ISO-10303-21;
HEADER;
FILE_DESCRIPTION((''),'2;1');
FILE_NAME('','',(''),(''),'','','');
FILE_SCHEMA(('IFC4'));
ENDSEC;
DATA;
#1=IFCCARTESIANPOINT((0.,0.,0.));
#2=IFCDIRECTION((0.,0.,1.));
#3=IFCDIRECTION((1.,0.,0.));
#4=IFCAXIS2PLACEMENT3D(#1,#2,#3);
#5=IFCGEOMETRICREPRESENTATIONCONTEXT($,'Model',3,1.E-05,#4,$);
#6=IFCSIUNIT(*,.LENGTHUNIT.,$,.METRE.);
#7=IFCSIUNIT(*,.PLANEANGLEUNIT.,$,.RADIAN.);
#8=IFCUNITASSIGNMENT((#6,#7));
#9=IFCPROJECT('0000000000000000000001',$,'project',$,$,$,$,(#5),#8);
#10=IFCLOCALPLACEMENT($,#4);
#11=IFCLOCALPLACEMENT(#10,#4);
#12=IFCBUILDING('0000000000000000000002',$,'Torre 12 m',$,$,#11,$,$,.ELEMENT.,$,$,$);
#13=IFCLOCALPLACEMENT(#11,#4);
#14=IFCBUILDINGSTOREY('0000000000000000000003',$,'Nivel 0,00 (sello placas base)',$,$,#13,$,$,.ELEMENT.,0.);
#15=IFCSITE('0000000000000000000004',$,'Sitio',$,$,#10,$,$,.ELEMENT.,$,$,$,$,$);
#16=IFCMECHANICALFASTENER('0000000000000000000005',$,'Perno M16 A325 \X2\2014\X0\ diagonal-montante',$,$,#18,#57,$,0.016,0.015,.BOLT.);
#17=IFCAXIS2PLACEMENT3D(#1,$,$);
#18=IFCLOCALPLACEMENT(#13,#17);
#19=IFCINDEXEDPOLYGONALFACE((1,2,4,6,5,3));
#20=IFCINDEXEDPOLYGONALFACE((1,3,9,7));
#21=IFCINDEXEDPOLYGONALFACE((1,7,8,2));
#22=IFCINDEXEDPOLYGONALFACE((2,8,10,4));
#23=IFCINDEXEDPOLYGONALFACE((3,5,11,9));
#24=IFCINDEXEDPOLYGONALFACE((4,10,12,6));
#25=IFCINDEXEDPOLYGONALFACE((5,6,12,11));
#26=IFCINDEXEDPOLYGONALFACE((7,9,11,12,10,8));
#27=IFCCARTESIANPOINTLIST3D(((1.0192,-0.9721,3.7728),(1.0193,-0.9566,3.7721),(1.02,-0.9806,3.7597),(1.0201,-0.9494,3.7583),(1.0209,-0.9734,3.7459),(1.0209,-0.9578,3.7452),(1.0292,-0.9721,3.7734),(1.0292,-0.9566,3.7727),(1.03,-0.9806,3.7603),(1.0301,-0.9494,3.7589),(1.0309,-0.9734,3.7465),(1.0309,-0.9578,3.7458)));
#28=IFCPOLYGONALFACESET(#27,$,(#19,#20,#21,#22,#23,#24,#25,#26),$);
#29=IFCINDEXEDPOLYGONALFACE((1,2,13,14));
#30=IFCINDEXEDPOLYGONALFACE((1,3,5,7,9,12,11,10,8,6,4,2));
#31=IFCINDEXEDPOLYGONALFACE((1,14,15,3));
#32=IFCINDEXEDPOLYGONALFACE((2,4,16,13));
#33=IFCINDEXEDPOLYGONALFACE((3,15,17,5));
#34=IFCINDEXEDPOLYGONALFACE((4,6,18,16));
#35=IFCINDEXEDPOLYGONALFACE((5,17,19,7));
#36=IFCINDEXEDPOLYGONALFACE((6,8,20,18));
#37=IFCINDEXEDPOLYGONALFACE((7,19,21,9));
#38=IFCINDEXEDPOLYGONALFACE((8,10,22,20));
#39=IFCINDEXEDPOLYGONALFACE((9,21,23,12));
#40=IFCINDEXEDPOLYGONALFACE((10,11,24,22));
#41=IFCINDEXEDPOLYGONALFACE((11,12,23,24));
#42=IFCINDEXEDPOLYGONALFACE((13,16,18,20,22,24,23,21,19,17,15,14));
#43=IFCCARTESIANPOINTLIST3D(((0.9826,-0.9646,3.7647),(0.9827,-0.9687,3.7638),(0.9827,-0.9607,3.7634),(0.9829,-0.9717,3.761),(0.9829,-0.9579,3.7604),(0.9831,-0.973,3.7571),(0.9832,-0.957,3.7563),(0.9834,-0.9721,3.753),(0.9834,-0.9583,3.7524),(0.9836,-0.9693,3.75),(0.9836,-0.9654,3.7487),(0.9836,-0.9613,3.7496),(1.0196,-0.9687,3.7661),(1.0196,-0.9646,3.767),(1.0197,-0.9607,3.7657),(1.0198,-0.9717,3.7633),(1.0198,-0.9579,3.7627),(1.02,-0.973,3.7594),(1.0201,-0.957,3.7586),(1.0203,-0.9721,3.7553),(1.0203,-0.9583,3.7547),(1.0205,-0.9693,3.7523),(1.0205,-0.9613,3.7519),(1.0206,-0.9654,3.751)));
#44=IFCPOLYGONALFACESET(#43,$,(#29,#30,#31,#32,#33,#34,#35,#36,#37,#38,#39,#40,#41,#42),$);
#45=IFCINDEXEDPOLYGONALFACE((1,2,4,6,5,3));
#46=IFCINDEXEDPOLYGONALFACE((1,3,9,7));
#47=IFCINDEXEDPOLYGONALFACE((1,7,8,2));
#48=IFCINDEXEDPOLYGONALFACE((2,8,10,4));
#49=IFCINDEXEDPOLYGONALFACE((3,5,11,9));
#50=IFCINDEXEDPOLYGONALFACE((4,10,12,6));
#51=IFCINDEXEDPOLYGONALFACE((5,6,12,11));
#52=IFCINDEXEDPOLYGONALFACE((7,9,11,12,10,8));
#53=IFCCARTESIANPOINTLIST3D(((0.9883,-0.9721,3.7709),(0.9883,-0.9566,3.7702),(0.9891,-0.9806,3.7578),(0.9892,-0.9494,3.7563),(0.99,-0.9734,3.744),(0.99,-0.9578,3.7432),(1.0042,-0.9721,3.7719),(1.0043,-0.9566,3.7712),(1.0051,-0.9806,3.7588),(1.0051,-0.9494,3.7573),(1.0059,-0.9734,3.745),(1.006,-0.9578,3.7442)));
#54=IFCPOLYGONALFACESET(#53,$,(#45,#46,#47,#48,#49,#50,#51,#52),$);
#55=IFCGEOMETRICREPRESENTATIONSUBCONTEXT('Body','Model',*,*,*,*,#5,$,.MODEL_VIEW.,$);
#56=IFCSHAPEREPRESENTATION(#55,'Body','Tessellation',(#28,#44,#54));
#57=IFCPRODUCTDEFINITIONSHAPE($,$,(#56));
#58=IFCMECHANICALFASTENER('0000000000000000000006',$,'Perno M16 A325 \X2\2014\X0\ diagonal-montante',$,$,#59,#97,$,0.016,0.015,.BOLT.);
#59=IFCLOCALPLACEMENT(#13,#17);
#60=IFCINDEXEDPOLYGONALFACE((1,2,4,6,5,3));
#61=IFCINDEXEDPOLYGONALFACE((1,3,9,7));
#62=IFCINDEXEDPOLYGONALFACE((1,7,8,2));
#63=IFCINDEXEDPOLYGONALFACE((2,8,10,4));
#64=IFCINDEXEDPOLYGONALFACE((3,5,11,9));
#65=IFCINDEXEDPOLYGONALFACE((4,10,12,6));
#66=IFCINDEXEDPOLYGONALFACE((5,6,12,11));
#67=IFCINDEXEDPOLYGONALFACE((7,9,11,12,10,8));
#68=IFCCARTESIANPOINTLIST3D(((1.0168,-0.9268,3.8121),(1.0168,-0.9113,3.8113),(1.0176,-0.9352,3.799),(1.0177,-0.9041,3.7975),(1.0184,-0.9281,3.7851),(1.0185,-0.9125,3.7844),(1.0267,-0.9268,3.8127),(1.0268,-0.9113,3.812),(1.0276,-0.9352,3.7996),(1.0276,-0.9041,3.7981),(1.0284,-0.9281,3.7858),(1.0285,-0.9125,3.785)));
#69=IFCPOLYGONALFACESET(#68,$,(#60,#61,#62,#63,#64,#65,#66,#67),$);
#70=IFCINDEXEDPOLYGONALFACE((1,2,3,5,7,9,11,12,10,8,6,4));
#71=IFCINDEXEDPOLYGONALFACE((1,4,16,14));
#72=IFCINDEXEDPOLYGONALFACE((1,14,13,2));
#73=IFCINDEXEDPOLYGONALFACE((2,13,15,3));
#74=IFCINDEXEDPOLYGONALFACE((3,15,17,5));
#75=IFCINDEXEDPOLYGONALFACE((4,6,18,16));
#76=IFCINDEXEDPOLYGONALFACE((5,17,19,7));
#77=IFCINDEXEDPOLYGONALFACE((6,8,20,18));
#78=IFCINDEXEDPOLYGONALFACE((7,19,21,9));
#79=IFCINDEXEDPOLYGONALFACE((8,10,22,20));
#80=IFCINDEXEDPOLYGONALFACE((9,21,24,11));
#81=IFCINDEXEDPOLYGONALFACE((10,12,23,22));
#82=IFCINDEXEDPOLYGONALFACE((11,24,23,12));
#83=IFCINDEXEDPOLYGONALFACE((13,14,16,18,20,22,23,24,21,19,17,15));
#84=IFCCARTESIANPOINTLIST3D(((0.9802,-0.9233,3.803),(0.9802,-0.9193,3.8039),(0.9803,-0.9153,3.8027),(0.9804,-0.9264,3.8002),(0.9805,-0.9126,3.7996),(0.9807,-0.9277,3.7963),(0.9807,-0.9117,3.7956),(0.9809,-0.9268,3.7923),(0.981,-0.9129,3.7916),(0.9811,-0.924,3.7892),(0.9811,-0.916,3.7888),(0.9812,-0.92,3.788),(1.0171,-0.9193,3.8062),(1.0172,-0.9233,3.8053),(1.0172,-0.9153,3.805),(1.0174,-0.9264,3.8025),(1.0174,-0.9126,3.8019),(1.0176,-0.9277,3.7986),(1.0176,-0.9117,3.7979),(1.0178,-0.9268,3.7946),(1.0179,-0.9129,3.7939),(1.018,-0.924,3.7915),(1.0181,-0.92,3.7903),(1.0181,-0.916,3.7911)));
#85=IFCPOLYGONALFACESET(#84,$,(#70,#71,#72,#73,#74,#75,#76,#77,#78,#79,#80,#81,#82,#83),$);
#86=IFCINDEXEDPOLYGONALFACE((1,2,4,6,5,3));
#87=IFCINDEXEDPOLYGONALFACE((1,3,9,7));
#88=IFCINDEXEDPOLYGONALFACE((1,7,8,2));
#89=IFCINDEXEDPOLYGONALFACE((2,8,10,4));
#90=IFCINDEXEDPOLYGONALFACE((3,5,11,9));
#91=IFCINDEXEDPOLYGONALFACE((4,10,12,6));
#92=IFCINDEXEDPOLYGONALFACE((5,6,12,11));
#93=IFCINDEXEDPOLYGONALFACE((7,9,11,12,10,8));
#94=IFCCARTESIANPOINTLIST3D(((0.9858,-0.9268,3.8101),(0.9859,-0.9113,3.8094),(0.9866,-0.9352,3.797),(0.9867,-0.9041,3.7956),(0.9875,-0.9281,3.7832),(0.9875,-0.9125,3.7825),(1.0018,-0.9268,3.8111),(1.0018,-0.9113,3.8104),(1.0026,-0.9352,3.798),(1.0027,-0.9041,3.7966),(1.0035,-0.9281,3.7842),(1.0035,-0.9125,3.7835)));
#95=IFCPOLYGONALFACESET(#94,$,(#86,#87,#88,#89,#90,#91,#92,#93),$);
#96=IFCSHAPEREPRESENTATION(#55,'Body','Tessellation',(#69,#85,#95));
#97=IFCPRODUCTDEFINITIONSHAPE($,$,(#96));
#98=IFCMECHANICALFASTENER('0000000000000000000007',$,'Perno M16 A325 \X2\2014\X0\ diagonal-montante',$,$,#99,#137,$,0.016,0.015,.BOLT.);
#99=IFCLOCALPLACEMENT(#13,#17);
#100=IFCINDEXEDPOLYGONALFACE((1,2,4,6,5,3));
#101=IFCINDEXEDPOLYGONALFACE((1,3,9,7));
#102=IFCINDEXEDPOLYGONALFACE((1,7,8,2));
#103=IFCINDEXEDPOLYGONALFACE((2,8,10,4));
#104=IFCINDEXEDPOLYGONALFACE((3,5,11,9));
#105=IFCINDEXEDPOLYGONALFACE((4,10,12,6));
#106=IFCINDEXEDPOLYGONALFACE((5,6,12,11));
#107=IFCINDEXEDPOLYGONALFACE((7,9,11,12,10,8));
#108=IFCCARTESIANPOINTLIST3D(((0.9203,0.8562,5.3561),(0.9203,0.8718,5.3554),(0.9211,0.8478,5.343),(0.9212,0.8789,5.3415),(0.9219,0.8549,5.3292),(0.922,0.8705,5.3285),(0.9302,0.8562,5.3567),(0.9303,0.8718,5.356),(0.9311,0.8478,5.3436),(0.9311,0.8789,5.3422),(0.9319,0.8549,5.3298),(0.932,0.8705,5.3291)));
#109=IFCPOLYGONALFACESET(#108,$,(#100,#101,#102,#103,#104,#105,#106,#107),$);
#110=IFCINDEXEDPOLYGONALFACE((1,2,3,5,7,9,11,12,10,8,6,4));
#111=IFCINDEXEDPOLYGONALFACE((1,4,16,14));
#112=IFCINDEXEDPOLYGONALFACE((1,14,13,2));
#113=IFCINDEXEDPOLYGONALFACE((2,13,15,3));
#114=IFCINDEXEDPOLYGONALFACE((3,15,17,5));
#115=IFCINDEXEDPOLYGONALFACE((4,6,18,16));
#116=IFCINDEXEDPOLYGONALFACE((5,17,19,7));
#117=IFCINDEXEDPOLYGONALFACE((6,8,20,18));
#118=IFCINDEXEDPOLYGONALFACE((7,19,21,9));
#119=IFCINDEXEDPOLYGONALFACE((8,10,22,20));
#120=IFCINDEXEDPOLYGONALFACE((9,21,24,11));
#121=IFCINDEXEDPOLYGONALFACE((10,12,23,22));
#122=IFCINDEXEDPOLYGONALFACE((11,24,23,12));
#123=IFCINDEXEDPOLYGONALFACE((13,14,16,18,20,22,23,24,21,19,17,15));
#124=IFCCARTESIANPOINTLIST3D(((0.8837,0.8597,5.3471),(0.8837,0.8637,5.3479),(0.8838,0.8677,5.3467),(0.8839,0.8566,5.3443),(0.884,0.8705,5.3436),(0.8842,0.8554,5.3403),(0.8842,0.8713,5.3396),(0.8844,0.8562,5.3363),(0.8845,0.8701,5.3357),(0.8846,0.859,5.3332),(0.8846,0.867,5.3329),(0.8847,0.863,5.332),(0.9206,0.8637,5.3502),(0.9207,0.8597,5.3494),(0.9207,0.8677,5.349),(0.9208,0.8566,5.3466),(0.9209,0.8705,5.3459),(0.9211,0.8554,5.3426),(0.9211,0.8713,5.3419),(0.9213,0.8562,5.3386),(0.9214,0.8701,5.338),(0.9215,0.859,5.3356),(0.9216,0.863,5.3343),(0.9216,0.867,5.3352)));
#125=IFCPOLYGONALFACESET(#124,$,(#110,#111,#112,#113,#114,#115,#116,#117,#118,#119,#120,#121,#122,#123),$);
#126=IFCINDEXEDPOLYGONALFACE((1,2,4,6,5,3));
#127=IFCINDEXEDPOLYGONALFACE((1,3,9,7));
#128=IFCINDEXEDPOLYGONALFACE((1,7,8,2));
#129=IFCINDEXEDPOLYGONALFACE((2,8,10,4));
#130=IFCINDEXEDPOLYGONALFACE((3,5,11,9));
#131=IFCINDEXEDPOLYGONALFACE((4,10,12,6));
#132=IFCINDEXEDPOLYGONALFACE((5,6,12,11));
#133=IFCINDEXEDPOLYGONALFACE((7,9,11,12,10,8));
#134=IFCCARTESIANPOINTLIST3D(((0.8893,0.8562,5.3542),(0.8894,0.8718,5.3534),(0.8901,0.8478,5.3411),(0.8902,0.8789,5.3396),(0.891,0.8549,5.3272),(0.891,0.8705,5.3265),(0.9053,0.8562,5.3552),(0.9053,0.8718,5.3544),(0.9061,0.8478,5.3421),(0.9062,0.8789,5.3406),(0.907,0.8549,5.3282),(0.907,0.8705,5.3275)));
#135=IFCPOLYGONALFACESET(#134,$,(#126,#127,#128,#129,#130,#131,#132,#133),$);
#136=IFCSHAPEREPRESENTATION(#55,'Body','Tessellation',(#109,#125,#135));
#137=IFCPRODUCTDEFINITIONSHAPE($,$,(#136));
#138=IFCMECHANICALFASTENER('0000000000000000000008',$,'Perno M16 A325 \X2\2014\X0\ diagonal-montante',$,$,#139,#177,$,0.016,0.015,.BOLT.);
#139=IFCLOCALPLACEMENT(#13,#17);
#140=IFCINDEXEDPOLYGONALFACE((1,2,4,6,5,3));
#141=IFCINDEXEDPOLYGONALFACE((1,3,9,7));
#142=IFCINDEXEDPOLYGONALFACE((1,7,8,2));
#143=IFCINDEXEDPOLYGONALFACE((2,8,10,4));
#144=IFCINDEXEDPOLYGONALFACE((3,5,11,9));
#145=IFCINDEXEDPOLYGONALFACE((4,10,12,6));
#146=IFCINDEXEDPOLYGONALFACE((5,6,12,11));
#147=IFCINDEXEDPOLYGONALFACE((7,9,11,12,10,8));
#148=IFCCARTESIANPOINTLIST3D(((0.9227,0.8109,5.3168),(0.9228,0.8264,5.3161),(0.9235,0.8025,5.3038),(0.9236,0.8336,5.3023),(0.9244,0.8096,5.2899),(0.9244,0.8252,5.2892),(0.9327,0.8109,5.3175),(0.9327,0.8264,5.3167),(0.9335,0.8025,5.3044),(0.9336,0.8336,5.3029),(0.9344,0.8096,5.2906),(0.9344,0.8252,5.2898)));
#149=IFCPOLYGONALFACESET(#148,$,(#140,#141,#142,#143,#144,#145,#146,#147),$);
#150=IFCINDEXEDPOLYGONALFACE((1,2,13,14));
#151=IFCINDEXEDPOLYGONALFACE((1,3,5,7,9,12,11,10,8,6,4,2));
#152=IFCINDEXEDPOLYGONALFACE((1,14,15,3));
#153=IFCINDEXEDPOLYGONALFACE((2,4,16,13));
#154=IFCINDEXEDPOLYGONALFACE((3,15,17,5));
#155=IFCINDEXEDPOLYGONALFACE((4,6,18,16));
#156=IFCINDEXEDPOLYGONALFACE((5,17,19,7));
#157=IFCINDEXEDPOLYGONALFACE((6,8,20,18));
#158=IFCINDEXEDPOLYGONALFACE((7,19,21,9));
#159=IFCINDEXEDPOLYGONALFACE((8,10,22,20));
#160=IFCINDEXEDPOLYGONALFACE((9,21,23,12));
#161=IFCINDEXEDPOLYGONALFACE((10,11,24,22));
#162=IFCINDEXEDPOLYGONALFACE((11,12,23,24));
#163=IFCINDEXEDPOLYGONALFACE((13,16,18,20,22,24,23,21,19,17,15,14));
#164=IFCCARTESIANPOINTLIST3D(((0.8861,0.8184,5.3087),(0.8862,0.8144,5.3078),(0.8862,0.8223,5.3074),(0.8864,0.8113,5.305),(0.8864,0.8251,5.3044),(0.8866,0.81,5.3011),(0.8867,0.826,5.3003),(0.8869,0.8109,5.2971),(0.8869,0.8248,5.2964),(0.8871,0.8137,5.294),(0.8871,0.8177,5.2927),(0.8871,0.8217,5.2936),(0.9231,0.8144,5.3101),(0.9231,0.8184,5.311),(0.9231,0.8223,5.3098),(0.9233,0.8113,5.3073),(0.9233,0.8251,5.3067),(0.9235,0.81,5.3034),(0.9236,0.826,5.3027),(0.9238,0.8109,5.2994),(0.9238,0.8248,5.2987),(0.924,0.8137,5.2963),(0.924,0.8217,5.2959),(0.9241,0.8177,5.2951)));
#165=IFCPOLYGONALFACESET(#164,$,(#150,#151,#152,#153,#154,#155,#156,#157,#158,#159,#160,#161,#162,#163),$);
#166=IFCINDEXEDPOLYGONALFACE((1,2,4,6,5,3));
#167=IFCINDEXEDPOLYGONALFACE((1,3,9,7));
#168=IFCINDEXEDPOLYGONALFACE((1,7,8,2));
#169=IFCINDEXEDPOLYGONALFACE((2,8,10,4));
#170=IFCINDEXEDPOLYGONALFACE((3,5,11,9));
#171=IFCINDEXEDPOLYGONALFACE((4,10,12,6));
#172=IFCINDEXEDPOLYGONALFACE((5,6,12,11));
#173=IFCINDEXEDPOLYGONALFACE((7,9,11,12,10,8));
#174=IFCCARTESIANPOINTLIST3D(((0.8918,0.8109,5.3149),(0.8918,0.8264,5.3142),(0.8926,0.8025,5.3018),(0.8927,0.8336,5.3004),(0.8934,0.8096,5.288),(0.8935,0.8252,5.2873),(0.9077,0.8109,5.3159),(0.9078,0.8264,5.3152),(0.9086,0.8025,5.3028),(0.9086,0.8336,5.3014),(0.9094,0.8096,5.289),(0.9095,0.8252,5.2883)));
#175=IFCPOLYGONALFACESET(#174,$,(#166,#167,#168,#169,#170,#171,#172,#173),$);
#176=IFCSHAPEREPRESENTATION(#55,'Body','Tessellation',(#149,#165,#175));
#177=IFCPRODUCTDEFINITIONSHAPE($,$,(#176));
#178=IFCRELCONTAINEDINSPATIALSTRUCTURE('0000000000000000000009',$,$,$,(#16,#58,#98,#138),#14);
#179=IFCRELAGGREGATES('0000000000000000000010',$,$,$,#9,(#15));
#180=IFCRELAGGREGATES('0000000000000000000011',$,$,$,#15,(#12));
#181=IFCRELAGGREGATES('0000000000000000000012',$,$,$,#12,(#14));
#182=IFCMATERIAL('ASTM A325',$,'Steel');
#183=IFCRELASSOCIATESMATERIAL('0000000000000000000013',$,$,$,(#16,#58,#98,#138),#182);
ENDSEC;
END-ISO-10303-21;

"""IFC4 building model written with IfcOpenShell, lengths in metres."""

from ifc_helpers import new_model, si_unit, frame, origin_with_axes, place, context, subcontext, project, spatial, polyline, outline, extrude, material, element, save


model = new_model("IFC4")

# Units and contexts
model_context = context("Model", 3, precision=1e-05, world=origin_with_axes())
body_context = subcontext(model_context, "Body", "Model", "MODEL_VIEW")
ifc_project = project(units=[si_unit("LENGTHUNIT", "METRE"), si_unit("PLANEANGLEUNIT", "RADIAN")], contexts=[model_context])

# Site, building, storey
site_placement = place(None, origin_with_axes())
site = spatial("IfcSite", under=ifc_project, at=site_placement, Name="Sitio", CompositionType="ELEMENT")
building_placement = place(site_placement, origin_with_axes())
building = spatial("IfcBuilding", under=site, at=building_placement, Name="Torre 12 m", CompositionType="ELEMENT")
storey_placement = place(building_placement, origin_with_axes())
storey = spatial("IfcBuildingStorey", under=building, at=storey_placement, Name="Nivel 0,00 (sello placas base)", CompositionType="ELEMENT", Elevation=0.0)

# Shared definitions
placement = place(storey_placement, origin_with_axes())

# Mechanical fasteners
ifc_material_1 = material(Name="ASTM A325", Category="Steel")
element("IfcMechanicalFastener", 1, at=placement, inside=storey, material=ifc_material_1, Name="Perno M16 A325 — diagonal-montante", NominalDiameter=0.016, NominalLength=0.015, PredefinedType="BOLT", context=body_context, shape_type="SweptSolid", body=[
    extrude(outline(polyline([(0.0135, 0.0078), (0.0, 0.0156), (-0.0135, 0.0078), (-0.0135, -0.0078), (0.0, -0.0156), (0.0135, -0.0078), (0.0135, 0.0078)])), frame((1.0301, -0.965, 3.7596), z_axis=(-0.998053, 0.0, -0.062378), x_axis=(0.033672, 0.841794, -0.538748)), (0.0, 0.0, 1.0), 0.01),
    extrude(outline(polyline([(0.008, 0.0), (0.0069, 0.004), (0.004, 0.0069), (0.0, 0.008), (-0.004, 0.0069), (-0.0069, 0.004), (-0.008, 0.0), (-0.0069, -0.004), (-0.004, -0.0069), (0.0, -0.008), (0.004, -0.0069), (0.0069, -0.004), (0.008, 0.0)])), frame((1.0201, -0.965, 3.759), z_axis=(-0.998053, 0.0, -0.062378), x_axis=(0.033672, 0.841794, -0.538748)), (0.0, 0.0, 1.0), 0.037),
    extrude(outline(polyline([(0.0135, 0.0078), (0.0, 0.0156), (-0.0135, 0.0078), (-0.0135, -0.0078), (0.0, -0.0156), (0.0135, -0.0078), (0.0135, 0.0078)])), frame((1.0051, -0.965, 3.7581), z_axis=(-0.998053, 0.0, -0.062378), x_axis=(0.033672, 0.841794, -0.538748)), (0.0, 0.0, 1.0), 0.016),
])
element("IfcMechanicalFastener", 2, at=placement, inside=storey, material=ifc_material_1, Name="Perno M16 A325 — diagonal-montante", NominalDiameter=0.016, NominalLength=0.015, PredefinedType="BOLT", context=body_context, shape_type="SweptSolid", body=[
    extrude(outline(polyline([(0.0135, 0.0078), (0.0, 0.0156), (-0.0135, 0.0078), (-0.0135, -0.0078), (0.0, -0.0156), (0.0135, -0.0078), (0.0135, 0.0078)])), frame((1.0276, -0.9197, 3.7989), z_axis=(-0.998053, 0.0, -0.062378), x_axis=(0.033672, 0.841794, -0.538748)), (0.0, 0.0, 1.0), 0.01),
    extrude(outline(polyline([(0.008, 0.0), (0.0069, 0.004), (0.004, 0.0069), (0.0, 0.008), (-0.004, 0.0069), (-0.0069, 0.004), (-0.008, 0.0), (-0.0069, -0.004), (-0.004, -0.0069), (0.0, -0.008), (0.004, -0.0069), (0.0069, -0.004), (0.008, 0.0)])), frame((1.0176, -0.9197, 3.7982), z_axis=(-0.998053, 0.0, -0.062378), x_axis=(0.033672, 0.841794, -0.538748)), (0.0, 0.0, 1.0), 0.037),
    extrude(outline(polyline([(0.0135, 0.0078), (0.0, 0.0156), (-0.0135, 0.0078), (-0.0135, -0.0078), (0.0, -0.0156), (0.0135, -0.0078), (0.0135, 0.0078)])), frame((1.0026, -0.9197, 3.7973), z_axis=(-0.998053, 0.0, -0.062378), x_axis=(0.033672, 0.841794, -0.538748)), (0.0, 0.0, 1.0), 0.016),
])
element("IfcMechanicalFastener", 3, at=placement, inside=storey, material=ifc_material_1, Name="Perno M16 A325 — diagonal-montante", NominalDiameter=0.016, NominalLength=0.015, PredefinedType="BOLT", context=body_context, shape_type="SweptSolid", body=[
    extrude(outline(polyline([(0.0135, 0.0078), (0.0, 0.0156), (-0.0135, 0.0078), (-0.0135, -0.0078), (0.0, -0.0156), (0.0135, -0.0078), (0.0135, 0.0078)])), frame((0.9311, 0.8633, 5.3429), z_axis=(-0.998053, 0.0, -0.062378), x_axis=(0.033672, 0.841794, -0.538748)), (0.0, 0.0, 1.0), 0.01),
    extrude(outline(polyline([(0.008, 0.0), (0.0069, 0.004), (0.004, 0.0069), (0.0, 0.008), (-0.004, 0.0069), (-0.0069, 0.004), (-0.008, 0.0), (-0.0069, -0.004), (-0.004, -0.0069), (0.0, -0.008), (0.004, -0.0069), (0.0069, -0.004), (0.008, 0.0)])), frame((0.9211, 0.8633, 5.3423), z_axis=(-0.998053, 0.0, -0.062378), x_axis=(0.033672, 0.841794, -0.538748)), (0.0, 0.0, 1.0), 0.037),
    extrude(outline(polyline([(0.0135, 0.0078), (0.0, 0.0156), (-0.0135, 0.0078), (-0.0135, -0.0078), (0.0, -0.0156), (0.0135, -0.0078), (0.0135, 0.0078)])), frame((0.9061, 0.8633, 5.3413), z_axis=(-0.998053, 0.0, -0.062378), x_axis=(0.033672, 0.841794, -0.538748)), (0.0, 0.0, 1.0), 0.016),
])
element("IfcMechanicalFastener", 4, at=placement, inside=storey, material=ifc_material_1, Name="Perno M16 A325 — diagonal-montante", NominalDiameter=0.016, NominalLength=0.015, PredefinedType="BOLT", context=body_context, shape_type="SweptSolid", body=[
    extrude(outline(polyline([(0.0135, 0.0078), (0.0, 0.0156), (-0.0135, 0.0078), (-0.0135, -0.0078), (0.0, -0.0156), (0.0135, -0.0078), (0.0135, 0.0078)])), frame((0.9336, 0.818, 5.3037), z_axis=(-0.998053, 0.0, -0.062378), x_axis=(0.033672, 0.841794, -0.538748)), (0.0, 0.0, 1.0), 0.01),
    extrude(outline(polyline([(0.008, 0.0), (0.0069, 0.004), (0.004, 0.0069), (0.0, 0.008), (-0.004, 0.0069), (-0.0069, 0.004), (-0.008, 0.0), (-0.0069, -0.004), (-0.004, -0.0069), (0.0, -0.008), (0.004, -0.0069), (0.0069, -0.004), (0.008, 0.0)])), frame((0.9236, 0.818, 5.303), z_axis=(-0.998053, 0.0, -0.062378), x_axis=(0.033672, 0.841794, -0.538748)), (0.0, 0.0, 1.0), 0.037),
    extrude(outline(polyline([(0.0135, 0.0078), (0.0, 0.0156), (-0.0135, 0.0078), (-0.0135, -0.0078), (0.0, -0.0156), (0.0135, -0.0078), (0.0135, 0.0078)])), frame((0.9086, 0.818, 5.3021), z_axis=(-0.998053, 0.0, -0.062378), x_axis=(0.033672, 0.841794, -0.538748)), (0.0, 0.0, 1.0), 0.016),
])

save(model, "model.ifc")
